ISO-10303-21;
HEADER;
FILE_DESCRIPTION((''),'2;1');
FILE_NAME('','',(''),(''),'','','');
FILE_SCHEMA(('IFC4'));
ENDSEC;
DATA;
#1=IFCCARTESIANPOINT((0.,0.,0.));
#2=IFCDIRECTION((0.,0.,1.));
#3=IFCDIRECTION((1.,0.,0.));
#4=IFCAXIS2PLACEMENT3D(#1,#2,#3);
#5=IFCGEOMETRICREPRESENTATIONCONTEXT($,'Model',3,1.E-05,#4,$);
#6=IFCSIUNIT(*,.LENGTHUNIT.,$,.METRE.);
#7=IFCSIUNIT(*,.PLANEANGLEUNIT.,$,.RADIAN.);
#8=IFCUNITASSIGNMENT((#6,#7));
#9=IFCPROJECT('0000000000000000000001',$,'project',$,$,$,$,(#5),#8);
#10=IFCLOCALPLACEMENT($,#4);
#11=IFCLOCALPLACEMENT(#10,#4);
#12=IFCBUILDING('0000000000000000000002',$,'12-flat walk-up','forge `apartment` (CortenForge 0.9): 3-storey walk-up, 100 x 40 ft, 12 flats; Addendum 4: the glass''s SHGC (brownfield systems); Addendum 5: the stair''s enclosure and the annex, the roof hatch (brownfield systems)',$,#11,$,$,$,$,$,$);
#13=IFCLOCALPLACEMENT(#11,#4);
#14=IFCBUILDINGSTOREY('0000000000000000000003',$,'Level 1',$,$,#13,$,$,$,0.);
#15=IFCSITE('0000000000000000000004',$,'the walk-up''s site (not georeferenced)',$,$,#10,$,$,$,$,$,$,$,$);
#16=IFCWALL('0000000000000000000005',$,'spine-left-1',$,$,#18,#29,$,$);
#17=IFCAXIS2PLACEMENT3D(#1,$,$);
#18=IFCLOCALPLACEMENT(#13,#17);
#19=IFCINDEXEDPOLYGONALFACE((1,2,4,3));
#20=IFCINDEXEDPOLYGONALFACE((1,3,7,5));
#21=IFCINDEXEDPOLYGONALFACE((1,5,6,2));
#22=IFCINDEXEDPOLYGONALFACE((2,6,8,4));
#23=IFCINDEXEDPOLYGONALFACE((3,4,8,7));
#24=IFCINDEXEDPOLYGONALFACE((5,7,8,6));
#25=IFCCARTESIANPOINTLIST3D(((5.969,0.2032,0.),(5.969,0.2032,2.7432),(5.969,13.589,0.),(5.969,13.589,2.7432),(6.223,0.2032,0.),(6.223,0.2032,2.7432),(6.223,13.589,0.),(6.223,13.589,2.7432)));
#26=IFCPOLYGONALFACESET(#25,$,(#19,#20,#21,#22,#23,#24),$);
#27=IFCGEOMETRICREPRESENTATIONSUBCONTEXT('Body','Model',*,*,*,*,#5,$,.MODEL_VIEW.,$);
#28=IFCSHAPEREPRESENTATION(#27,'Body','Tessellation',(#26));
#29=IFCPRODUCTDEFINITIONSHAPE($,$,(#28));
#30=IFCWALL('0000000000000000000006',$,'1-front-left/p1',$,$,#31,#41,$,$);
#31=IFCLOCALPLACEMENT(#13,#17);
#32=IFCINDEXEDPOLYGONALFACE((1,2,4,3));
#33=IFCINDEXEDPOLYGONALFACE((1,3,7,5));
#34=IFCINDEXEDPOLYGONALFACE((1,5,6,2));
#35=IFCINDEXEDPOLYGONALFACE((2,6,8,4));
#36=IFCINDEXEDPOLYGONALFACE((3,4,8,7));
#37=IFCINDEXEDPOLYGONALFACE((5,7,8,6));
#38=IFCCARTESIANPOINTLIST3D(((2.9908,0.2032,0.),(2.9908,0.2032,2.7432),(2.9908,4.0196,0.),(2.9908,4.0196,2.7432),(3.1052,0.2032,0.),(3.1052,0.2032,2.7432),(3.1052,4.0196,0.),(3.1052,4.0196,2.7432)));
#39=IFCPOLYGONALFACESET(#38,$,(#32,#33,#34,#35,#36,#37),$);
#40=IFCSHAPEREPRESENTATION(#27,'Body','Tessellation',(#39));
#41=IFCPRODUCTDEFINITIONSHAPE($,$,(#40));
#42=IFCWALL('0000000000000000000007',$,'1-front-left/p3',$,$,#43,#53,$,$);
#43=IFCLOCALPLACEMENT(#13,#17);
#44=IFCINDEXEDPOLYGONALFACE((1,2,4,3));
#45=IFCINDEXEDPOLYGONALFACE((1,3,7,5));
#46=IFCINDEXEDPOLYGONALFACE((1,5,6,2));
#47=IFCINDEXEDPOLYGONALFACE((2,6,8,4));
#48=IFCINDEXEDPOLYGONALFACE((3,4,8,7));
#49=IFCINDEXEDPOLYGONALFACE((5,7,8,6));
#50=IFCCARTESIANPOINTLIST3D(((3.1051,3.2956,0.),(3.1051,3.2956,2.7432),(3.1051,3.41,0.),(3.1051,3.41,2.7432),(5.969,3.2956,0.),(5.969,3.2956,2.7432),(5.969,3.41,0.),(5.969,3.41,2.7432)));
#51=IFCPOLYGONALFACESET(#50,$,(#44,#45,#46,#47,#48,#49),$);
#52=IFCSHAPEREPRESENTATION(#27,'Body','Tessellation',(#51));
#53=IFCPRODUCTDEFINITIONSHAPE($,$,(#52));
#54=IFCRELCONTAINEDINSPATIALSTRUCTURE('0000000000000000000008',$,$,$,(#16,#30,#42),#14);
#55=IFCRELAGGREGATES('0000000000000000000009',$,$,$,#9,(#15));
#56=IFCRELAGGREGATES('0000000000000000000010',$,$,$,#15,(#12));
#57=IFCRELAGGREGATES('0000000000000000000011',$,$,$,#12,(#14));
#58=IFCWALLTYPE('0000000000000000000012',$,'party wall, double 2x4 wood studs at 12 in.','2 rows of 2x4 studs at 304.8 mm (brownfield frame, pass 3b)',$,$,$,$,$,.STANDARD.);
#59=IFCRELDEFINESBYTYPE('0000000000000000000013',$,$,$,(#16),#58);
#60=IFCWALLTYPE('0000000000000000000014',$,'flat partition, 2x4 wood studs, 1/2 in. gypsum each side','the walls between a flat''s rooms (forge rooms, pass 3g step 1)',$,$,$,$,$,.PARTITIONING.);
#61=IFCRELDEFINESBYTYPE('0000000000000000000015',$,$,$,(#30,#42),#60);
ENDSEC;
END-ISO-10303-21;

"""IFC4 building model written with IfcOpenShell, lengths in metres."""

from ifc_helpers import new_model, si_unit, frame, frame_2d, origin, origin_with_axes, place, context, subcontext, project, spatial, rectangle, extrude, type_object, element, save


model = new_model("IFC4")

# Units and contexts
model_context = context("Model", 3, precision=1e-05, world=origin_with_axes())
body_context = subcontext(model_context, "Body", "Model", "MODEL_VIEW")
ifc_project = project(units=[si_unit("LENGTHUNIT", "METRE"), si_unit("PLANEANGLEUNIT", "RADIAN")], contexts=[model_context])

# Site, building, storey
site_placement = place(None, origin_with_axes())
site = spatial("IfcSite", under=ifc_project, at=site_placement, Name="the walk-up's site (not georeferenced)")
building_placement = place(site_placement, origin_with_axes())
building = spatial("IfcBuilding", under=site, at=building_placement, Name="12-flat walk-up", Description="forge `apartment` (CortenForge 0.9): 3-storey walk-up, 100 x 40 ft, 12 flats; Addendum 4: the glass's SHGC (brownfield systems); Addendum 5: the stair's enclosure and the annex, the roof hatch (brownfield systems)")
storey_placement = place(building_placement, origin_with_axes())
storey = spatial("IfcBuildingStorey", under=building, at=storey_placement, Name="Level 1", Elevation=0.0)

# Walls
wall_type_1 = type_object("IfcWallType", Name="party wall, double 2x4 wood studs at 12 in.", Description="2 rows of 2x4 studs at 304.8 mm (brownfield frame, pass 3b)", PredefinedType="STANDARD")
wall_1_placement = place(storey_placement, frame((5.969, 0.2032, 0.0), z_axis=(0.0, 0.0, 1.0), x_axis=(1.0, 0.0, 0.0)))
element("IfcWall", 1, at=wall_1_placement, inside=storey, type_object=wall_type_1, Name="spine-left-1", context=body_context, shape_type="SweptSolid", body=[
    extrude(rectangle(XDim=0.254, YDim=13.3858, at=frame_2d((0.127, 6.6929))), origin(), (0.0, 0.0, 1.0), 2.7432),
])
wall_type_2 = type_object("IfcWallType", Name="flat partition, 2x4 wood studs, 1/2 in. gypsum each side", Description="the walls between a flat's rooms (forge rooms, pass 3g step 1)", PredefinedType="PARTITIONING")
wall_2_placement = place(storey_placement, frame((2.9909, 0.2032, 0.0), z_axis=(0.0, 0.0, 1.0), x_axis=(1.0, 0.0, 0.0)))
element("IfcWall", 2, at=wall_2_placement, inside=storey, type_object=wall_type_2, Name="1-front-left/p1", context=body_context, shape_type="SweptSolid", body=[
    extrude(rectangle(XDim=0.1143, YDim=3.8163, at=frame_2d((0.0572, 1.9082))), origin(), (0.0, 0.0, 1.0), 2.7432),
])
wall_3_placement = place(storey_placement, frame((3.1051, 3.2957, 0.0), z_axis=(0.0, 0.0, 1.0), x_axis=(1.0, 0.0, 0.0)))
element("IfcWall", 3, at=wall_3_placement, inside=storey, type_object=wall_type_2, Name="1-front-left/p3", context=body_context, shape_type="SweptSolid", body=[
    extrude(rectangle(XDim=2.8639, YDim=0.1143, at=frame_2d((1.4319, 0.0571))), origin(), (0.0, 0.0, 1.0), 2.7432),
])

save(model, "model.ifc")
